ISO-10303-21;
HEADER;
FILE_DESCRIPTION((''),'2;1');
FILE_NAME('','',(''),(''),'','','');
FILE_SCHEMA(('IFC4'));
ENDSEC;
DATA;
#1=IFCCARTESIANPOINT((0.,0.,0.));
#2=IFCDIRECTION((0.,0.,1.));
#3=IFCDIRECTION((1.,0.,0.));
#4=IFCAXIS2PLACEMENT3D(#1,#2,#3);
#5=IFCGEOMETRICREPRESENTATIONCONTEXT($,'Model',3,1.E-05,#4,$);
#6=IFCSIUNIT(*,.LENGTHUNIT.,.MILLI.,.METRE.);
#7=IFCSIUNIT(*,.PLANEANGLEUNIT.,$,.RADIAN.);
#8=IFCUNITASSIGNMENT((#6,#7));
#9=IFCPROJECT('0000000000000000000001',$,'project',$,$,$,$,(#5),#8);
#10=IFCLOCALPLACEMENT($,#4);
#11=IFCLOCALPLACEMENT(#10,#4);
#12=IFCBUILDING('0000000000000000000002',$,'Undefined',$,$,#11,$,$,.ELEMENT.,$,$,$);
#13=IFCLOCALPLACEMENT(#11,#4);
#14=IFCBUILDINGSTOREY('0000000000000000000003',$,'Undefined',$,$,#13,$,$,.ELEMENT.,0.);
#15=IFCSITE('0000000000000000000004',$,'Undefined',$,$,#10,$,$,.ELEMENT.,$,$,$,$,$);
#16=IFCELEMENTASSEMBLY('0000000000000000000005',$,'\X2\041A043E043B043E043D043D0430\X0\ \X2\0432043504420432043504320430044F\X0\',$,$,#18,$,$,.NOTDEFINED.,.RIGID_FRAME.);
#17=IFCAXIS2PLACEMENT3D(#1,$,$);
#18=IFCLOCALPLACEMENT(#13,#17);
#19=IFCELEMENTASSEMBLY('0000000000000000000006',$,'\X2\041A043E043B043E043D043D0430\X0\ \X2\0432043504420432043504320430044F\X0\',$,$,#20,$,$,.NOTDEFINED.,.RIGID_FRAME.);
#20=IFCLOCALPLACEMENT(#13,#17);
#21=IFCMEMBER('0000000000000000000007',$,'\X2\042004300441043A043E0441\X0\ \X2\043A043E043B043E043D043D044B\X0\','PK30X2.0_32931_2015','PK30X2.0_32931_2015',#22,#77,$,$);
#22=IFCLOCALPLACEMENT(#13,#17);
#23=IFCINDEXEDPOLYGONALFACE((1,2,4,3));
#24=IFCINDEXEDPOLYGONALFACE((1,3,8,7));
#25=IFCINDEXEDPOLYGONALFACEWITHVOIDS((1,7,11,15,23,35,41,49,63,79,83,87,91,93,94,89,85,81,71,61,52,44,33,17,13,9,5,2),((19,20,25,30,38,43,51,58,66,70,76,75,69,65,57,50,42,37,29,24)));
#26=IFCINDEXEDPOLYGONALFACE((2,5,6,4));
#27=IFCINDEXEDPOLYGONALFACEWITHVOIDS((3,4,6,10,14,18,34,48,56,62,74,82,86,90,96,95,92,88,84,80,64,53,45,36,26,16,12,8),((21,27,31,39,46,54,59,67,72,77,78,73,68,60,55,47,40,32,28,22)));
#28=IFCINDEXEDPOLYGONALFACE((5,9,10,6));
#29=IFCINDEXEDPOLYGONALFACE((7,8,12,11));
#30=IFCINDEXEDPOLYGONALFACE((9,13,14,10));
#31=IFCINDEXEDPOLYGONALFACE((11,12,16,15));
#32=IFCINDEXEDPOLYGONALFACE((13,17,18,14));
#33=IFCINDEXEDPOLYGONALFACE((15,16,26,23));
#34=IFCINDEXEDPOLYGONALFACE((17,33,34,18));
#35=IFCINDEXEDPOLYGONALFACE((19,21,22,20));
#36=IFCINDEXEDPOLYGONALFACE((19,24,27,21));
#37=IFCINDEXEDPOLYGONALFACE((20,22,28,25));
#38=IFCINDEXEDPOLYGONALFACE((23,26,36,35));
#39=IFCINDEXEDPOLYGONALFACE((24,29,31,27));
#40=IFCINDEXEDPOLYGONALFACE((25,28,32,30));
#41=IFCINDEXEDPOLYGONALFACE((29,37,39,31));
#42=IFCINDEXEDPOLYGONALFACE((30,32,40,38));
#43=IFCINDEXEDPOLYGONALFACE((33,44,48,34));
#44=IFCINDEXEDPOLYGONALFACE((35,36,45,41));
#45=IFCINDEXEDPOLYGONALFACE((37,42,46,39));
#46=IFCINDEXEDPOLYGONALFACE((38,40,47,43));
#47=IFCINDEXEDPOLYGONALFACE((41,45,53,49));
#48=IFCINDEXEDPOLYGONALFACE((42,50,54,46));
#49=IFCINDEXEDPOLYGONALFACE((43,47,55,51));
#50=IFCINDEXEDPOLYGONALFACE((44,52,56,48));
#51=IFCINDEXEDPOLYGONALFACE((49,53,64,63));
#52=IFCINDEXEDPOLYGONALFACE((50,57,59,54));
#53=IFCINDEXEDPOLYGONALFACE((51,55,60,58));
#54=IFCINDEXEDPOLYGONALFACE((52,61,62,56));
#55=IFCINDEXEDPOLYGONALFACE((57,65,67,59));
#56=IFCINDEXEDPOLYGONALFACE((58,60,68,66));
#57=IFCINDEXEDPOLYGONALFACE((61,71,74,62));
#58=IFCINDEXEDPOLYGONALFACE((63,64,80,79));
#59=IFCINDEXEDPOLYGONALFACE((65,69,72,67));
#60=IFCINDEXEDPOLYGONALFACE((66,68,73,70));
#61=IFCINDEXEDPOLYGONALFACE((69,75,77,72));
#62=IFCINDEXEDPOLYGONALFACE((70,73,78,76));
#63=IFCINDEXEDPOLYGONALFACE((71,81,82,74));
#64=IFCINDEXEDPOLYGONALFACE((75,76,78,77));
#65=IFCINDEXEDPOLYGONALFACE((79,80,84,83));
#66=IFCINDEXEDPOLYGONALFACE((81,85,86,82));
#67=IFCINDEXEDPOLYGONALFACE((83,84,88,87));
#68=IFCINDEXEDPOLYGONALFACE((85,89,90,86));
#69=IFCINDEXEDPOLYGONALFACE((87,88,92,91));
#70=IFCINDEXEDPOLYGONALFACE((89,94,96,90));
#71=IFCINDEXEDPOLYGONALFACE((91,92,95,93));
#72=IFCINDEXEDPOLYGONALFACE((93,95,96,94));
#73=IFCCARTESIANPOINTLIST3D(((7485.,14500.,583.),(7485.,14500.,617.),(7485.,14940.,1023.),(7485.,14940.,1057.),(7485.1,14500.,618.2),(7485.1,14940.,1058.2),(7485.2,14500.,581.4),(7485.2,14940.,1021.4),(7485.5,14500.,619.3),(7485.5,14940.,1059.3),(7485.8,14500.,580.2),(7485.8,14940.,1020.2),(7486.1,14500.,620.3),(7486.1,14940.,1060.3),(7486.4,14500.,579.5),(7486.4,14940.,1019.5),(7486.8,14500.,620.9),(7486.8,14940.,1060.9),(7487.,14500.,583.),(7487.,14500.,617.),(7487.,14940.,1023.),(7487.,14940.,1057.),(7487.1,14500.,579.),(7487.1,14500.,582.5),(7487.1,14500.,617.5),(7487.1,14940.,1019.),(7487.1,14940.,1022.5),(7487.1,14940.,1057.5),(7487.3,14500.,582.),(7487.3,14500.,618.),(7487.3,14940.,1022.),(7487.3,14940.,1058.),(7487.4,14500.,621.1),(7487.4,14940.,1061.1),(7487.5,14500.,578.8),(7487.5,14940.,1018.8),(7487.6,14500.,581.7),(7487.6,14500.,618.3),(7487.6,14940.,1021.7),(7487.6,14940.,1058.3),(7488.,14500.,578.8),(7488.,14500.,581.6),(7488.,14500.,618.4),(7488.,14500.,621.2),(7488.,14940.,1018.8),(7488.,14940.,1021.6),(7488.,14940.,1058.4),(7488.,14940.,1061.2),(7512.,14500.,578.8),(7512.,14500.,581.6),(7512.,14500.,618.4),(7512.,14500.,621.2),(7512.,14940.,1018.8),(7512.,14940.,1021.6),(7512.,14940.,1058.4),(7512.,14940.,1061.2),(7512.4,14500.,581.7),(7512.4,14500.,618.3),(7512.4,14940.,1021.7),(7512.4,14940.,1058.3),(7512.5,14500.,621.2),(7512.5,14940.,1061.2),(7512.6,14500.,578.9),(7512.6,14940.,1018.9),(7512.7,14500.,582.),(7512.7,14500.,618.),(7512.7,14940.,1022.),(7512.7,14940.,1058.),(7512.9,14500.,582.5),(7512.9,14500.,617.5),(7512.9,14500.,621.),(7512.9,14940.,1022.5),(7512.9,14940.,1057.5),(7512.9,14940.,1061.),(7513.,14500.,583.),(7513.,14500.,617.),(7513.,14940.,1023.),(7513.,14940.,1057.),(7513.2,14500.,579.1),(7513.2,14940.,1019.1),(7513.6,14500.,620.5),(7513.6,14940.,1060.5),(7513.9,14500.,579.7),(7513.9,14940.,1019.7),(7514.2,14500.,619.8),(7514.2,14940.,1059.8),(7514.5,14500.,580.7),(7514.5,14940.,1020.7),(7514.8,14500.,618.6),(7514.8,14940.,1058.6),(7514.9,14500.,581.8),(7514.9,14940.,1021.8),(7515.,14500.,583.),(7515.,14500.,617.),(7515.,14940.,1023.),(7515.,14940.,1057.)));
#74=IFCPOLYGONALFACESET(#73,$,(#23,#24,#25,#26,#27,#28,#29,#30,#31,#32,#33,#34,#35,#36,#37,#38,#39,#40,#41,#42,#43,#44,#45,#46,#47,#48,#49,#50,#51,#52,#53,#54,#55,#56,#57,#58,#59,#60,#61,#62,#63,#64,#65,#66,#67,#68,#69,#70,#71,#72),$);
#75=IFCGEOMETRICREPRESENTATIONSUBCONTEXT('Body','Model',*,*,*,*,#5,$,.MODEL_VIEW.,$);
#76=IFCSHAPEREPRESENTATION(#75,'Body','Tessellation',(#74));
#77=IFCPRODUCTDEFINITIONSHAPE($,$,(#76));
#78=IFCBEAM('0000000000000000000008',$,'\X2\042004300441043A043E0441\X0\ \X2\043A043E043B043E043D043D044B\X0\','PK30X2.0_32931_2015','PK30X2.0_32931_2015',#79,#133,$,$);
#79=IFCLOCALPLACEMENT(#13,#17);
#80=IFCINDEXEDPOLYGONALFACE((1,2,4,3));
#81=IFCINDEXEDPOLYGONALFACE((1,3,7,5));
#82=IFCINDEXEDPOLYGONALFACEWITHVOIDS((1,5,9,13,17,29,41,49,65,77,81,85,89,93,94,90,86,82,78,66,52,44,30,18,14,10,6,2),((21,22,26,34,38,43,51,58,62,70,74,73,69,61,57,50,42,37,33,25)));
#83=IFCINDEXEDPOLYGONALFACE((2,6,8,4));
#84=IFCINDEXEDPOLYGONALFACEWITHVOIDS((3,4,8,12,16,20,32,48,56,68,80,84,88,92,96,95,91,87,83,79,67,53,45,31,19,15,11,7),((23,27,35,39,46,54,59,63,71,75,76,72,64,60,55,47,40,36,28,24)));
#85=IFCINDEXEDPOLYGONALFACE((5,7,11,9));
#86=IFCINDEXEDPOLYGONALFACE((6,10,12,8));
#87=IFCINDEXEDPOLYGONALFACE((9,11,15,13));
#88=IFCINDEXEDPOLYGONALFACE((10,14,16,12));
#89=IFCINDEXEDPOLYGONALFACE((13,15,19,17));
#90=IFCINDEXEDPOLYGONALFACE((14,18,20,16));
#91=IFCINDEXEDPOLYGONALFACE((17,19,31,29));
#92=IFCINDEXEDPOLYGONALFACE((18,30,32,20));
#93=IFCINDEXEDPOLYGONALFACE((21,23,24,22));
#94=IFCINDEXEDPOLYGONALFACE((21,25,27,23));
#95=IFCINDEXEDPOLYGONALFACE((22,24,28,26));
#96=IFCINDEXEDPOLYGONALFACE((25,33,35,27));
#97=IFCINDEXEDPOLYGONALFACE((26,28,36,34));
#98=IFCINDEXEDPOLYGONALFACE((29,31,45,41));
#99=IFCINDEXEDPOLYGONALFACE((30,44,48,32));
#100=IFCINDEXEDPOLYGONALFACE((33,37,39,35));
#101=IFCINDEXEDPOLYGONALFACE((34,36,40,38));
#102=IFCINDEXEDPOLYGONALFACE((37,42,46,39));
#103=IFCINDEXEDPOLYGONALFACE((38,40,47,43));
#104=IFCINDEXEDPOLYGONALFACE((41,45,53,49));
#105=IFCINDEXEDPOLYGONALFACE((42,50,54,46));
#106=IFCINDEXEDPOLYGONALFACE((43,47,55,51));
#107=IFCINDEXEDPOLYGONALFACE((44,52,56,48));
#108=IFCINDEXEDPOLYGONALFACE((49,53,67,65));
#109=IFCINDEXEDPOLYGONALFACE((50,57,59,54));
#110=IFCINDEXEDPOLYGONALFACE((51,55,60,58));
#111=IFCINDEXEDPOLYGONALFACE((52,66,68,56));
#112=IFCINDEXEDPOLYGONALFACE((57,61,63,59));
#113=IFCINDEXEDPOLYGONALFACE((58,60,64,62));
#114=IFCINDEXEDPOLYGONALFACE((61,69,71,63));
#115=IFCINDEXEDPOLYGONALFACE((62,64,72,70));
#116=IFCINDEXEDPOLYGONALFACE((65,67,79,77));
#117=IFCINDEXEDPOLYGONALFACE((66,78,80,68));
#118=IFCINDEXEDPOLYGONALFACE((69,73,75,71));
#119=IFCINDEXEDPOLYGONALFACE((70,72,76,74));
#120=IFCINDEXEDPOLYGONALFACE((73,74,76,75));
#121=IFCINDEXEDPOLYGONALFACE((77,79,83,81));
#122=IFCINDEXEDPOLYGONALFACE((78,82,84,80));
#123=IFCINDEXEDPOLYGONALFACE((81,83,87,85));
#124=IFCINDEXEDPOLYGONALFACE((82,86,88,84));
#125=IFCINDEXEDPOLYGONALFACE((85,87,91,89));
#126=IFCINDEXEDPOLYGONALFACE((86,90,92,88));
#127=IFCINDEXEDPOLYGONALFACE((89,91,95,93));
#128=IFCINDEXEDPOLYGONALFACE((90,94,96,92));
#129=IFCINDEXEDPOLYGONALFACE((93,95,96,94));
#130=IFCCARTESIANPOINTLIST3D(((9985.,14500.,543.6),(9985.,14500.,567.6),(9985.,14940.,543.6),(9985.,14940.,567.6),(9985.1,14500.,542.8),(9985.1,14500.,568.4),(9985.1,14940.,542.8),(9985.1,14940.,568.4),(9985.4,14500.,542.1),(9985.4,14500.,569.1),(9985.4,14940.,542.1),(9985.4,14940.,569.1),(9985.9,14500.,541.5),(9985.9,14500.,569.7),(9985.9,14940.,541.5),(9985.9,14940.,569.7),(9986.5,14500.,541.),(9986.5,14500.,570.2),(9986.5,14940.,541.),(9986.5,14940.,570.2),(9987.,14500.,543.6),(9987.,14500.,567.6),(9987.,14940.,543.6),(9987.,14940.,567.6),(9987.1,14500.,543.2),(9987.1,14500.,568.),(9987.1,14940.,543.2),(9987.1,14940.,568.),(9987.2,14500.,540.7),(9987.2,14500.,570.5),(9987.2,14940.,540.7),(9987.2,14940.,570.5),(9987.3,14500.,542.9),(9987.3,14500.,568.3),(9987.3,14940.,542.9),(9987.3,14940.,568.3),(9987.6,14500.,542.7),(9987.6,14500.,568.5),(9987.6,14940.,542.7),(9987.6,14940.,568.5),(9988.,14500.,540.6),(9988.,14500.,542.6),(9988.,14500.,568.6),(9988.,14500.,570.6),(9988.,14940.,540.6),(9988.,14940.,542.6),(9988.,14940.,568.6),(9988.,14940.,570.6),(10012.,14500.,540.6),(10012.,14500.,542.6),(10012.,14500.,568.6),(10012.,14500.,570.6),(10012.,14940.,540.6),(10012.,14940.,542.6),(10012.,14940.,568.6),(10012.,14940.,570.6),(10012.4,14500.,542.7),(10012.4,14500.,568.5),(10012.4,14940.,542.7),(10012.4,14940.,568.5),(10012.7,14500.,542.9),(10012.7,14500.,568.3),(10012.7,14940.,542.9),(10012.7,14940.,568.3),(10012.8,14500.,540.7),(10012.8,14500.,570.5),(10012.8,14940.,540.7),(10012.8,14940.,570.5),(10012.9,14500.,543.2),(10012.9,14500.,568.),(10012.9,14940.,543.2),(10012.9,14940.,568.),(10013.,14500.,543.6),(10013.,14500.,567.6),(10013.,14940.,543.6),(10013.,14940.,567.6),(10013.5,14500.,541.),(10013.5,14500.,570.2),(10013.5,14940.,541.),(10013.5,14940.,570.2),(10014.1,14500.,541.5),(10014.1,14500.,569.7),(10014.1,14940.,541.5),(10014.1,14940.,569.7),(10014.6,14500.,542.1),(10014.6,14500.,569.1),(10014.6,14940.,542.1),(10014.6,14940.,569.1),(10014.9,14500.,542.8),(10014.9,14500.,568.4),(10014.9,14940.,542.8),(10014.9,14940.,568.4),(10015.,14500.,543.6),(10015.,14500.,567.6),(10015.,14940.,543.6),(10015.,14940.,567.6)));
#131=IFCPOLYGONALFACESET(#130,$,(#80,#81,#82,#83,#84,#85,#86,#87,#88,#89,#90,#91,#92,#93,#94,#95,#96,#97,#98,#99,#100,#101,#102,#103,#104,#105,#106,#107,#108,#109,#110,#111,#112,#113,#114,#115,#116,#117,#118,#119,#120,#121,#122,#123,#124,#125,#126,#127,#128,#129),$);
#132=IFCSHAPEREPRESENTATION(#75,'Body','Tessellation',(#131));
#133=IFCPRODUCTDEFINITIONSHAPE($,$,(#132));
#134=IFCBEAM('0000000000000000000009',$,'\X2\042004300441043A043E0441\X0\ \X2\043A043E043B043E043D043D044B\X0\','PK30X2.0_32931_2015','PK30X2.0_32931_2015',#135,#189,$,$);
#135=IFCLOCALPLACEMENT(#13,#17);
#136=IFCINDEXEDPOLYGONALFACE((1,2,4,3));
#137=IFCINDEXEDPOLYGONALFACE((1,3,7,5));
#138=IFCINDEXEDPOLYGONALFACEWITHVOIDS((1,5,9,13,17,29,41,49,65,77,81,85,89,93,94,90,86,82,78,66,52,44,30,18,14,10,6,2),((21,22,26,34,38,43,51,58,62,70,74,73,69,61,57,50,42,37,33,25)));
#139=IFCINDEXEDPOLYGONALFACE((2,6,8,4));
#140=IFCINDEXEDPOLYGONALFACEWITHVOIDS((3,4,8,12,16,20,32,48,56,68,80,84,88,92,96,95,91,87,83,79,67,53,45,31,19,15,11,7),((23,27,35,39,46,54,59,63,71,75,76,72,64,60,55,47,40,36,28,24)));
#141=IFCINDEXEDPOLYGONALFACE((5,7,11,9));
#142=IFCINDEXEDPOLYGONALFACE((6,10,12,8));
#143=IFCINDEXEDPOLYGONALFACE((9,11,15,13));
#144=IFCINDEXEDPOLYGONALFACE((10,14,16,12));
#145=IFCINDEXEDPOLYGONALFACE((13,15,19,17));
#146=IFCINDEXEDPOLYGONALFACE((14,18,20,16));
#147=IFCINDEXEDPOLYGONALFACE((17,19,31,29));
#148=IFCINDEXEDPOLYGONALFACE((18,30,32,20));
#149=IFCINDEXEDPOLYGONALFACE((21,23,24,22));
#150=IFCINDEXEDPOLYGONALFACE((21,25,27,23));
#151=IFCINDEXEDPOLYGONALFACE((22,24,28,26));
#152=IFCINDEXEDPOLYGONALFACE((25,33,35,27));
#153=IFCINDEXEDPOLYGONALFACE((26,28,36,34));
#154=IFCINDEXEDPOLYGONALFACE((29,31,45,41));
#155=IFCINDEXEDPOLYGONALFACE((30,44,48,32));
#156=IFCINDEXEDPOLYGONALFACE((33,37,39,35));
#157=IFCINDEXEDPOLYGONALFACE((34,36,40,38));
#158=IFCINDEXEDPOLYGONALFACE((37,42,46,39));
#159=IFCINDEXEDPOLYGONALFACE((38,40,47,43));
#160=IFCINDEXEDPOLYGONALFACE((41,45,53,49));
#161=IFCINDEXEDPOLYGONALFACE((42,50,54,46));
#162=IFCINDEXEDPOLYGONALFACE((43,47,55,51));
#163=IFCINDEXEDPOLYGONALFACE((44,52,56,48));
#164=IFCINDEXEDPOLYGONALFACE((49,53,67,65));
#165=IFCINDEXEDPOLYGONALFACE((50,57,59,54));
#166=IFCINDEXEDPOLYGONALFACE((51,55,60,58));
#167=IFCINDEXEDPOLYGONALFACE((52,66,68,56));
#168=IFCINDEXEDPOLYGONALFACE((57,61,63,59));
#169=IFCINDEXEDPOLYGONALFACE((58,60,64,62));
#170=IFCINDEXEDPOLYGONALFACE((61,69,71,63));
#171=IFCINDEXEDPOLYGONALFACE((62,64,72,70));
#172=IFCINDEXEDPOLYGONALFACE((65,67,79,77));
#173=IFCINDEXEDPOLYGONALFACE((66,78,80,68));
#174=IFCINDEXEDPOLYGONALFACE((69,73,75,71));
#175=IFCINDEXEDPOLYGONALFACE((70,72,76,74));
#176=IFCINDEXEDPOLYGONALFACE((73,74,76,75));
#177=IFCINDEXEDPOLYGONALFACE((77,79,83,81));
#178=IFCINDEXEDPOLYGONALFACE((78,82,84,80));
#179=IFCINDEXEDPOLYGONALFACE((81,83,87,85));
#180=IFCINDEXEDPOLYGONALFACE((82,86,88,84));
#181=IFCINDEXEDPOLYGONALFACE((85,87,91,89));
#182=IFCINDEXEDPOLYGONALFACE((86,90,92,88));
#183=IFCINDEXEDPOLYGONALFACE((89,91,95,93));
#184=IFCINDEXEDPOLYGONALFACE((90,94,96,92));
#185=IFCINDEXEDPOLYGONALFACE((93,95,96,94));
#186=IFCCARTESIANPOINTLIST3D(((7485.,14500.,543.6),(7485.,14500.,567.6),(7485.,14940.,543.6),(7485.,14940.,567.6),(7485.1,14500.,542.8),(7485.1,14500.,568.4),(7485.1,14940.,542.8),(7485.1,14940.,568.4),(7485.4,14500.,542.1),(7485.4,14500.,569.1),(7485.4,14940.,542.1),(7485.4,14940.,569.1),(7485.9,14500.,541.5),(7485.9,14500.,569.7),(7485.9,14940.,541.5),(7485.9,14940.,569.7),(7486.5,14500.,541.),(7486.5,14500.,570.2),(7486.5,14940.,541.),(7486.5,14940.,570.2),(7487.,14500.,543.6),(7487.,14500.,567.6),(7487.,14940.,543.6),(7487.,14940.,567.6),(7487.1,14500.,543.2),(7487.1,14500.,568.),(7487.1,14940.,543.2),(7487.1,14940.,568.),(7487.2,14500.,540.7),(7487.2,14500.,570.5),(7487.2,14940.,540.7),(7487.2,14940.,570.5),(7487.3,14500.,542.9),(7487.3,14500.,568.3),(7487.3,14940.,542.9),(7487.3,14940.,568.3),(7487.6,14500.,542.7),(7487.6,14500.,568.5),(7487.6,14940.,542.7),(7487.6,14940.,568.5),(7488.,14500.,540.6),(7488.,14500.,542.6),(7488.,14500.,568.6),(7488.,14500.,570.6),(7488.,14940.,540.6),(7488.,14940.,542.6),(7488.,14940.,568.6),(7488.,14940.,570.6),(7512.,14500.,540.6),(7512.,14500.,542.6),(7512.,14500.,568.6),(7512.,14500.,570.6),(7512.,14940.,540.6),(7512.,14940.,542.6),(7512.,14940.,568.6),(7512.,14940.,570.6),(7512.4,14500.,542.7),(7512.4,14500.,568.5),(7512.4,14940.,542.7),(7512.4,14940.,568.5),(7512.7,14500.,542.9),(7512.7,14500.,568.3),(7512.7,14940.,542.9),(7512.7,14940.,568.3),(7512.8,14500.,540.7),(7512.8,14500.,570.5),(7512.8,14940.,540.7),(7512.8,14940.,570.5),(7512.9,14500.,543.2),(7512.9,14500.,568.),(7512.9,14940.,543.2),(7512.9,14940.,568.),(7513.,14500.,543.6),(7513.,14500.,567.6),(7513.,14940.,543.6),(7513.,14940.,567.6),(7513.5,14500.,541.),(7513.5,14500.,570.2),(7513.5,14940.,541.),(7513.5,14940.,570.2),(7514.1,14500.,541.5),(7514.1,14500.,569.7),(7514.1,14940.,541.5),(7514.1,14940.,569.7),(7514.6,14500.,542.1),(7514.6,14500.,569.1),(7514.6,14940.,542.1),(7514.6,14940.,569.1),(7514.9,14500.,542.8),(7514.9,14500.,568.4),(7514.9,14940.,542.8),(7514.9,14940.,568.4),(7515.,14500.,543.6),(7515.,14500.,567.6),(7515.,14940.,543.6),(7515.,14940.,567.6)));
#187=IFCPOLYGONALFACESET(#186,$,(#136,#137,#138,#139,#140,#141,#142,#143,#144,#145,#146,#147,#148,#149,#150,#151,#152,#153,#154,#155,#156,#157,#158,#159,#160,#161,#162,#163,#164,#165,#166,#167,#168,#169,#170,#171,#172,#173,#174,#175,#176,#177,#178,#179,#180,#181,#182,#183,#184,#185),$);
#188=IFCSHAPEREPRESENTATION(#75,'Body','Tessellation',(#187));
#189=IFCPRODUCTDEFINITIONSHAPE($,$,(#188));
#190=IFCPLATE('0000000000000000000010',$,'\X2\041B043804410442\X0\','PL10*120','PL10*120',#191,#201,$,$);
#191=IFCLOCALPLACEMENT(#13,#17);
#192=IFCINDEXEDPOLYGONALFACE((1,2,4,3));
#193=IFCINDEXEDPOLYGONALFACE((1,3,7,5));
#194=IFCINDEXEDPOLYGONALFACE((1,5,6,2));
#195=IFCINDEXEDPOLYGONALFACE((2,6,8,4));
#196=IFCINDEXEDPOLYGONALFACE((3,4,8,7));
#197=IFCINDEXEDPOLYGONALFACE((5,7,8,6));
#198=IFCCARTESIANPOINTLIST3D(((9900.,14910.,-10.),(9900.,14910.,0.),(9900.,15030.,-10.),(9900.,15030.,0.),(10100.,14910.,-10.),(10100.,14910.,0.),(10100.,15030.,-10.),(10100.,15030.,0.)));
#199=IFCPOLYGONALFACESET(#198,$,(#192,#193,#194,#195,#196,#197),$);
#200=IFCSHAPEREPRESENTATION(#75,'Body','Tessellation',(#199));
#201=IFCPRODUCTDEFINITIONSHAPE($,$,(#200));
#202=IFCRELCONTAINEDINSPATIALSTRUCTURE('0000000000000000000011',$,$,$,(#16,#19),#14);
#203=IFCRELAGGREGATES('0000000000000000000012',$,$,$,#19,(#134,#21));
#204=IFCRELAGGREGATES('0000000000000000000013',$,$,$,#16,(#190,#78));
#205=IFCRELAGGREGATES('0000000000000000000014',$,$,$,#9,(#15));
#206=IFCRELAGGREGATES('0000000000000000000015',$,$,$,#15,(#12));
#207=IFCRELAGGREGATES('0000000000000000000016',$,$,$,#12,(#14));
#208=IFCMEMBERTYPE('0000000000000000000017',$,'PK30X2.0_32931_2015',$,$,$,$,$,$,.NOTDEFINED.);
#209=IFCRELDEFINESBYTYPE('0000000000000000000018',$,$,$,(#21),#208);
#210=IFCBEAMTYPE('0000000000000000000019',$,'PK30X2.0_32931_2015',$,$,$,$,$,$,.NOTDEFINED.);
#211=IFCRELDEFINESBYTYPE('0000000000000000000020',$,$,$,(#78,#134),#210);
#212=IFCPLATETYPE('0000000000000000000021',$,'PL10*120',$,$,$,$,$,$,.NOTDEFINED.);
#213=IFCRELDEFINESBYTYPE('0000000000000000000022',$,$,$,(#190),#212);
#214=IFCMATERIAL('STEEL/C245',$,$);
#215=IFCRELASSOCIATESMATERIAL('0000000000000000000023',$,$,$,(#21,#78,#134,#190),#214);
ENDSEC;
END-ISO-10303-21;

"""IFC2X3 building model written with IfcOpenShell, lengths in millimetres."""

from ifc_helpers import new_model, si_unit, frame, origin_with_axes, origin_2d_with_axis, place, context, subcontext, project, spatial, polyline, hollow_rectangle, outline, extrude, clip, halfspace, material, type_object, element, aggregate, save


model = new_model("IFC2X3")

# Units and contexts
model_context = context("Model", 3, precision=1e-05, world=origin_with_axes())
body_context = subcontext(model_context, "Body", "Model", "MODEL_VIEW")
ifc_project = project(units=[si_unit("LENGTHUNIT", "METRE", prefix="MILLI"), si_unit("PLANEANGLEUNIT", "RADIAN")], contexts=[model_context])

# Site, building, storey
site_placement = place(None, origin_with_axes())
site = spatial("IfcSite", under=ifc_project, at=site_placement, Name="Undefined", CompositionType="ELEMENT")
building_placement = place(site_placement, origin_with_axes())
building = spatial("IfcBuilding", under=site, at=building_placement, Name="Undefined", CompositionType="ELEMENT")
storey_placement = place(building_placement, origin_with_axes())
storey = spatial("IfcBuildingStorey", under=building, at=storey_placement, Name="Undefined", CompositionType="ELEMENT", Elevation=0.0)

# Element assembly
assembly_1_placement = place(storey_placement, origin_with_axes())
assembly_1 = element("IfcElementAssembly", 1, at=assembly_1_placement, inside=storey, Name="Колонна ветвевая", AssemblyPlace="NOTDEFINED", PredefinedType="RIGID_FRAME")
ifc_material_1 = material(Name="STEEL/C245")

# Element assembly
assembly_2_placement = place(storey_placement, origin_with_axes())
assembly_2 = element("IfcElementAssembly", 2, at=assembly_2_placement, inside=storey, Name="Колонна ветвевая", AssemblyPlace="NOTDEFINED", PredefinedType="RIGID_FRAME")

# Member
member_type_1 = type_object("IfcMemberType", Name="PK30X2.0_32931_2015", PredefinedType="NOTDEFINED")
member_1_placement = place(assembly_2_placement, frame((7500.0, 14470.0, 570.0), z_axis=(0.0, -0.707107, 0.707107), x_axis=(0.0, 0.707107, 0.707107)))
member_1 = element("IfcMember", 3, at=member_1_placement, type_object=member_type_1, material=ifc_material_1, Name="Раскос колонны", Description="PK30X2.0_32931_2015", ObjectType="PK30X2.0_32931_2015", context=body_context, shape_type="Clipping", body=[
    clip(clip(extrude(hollow_rectangle(XDim=30.0, YDim=30.0, WallThickness=2.0, InnerFilletRadius=1.0, OuterFilletRadius=3.0, at=origin_2d_with_axis()), frame((695.0, 0.0, 0.0), z_axis=(-1.0, 0.0, 0.0), x_axis=(0.0, -1.0, 0.0)), (0.0, 0.0, 1.0), 682.9), halfspace(frame((629.0, 0.0, -35.7), z_axis=(-0.707107, 0.0, 0.707107), x_axis=(0.707107, 0.0, 0.707107)), True)), halfspace(frame((65.2, 0.0, 22.8), z_axis=(-0.707107, 0.0, 0.707107), x_axis=(0.707107, 0.0, 0.707107)), False)),
])

# Beams
beam_type_1 = type_object("IfcBeamType", Name="PK30X2.0_32931_2015", PredefinedType="NOTDEFINED")
beam_1_placement = place(assembly_1_placement, frame((10000.0, 14500.0, 555.6), z_axis=(0.0, 0.0, 1.0), x_axis=(0.0, 1.0, 0.0)))
beam_1 = element("IfcBeam", 4, at=beam_1_placement, type_object=beam_type_1, material=ifc_material_1, Name="Раскос колонны", Description="PK30X2.0_32931_2015", ObjectType="PK30X2.0_32931_2015", context=body_context, shape_type="SweptSolid", body=[
    extrude(hollow_rectangle(XDim=30.0, YDim=30.0, WallThickness=2.0, InnerFilletRadius=1.0, OuterFilletRadius=3.0, at=origin_2d_with_axis()), frame((440.0, 0.0, 0.0), z_axis=(-1.0, 0.0, 0.0), x_axis=(0.0, -1.0, 0.0)), (0.0, 0.0, 1.0), 440.0),
])
beam_2_placement = place(assembly_2_placement, frame((7500.0, 14500.0, 555.6), z_axis=(0.0, 0.0, 1.0), x_axis=(0.0, 1.0, 0.0)))
beam_2 = element("IfcBeam", 5, at=beam_2_placement, type_object=beam_type_1, material=ifc_material_1, Name="Раскос колонны", Description="PK30X2.0_32931_2015", ObjectType="PK30X2.0_32931_2015", context=body_context, shape_type="SweptSolid", body=[
    extrude(hollow_rectangle(XDim=30.0, YDim=30.0, WallThickness=2.0, InnerFilletRadius=1.0, OuterFilletRadius=3.0, at=origin_2d_with_axis()), frame((440.0, 0.0, 0.0), z_axis=(-1.0, 0.0, 0.0), x_axis=(0.0, -1.0, 0.0)), (0.0, 0.0, 1.0), 440.0),
])
aggregate(assembly_2, [beam_2, member_1])

# Plate
plate_type = type_object("IfcPlateType", Name="PL10*120", PredefinedType="NOTDEFINED")
plate_placement = place(assembly_1_placement, frame((9900.0, 14910.0, -5.0), z_axis=(0.0, 0.0, 1.0), x_axis=(1.0, 0.0, 0.0)))
plate = element("IfcPlate", 6, at=plate_placement, type_object=plate_type, material=ifc_material_1, Name="Лист", Description="PL10*120", ObjectType="PL10*120", context=body_context, shape_type="SweptSolid", body=[
    extrude(outline(polyline([(0.0, 0.0), (200.0, 0.0), (200.0, 120.0), (0.0, 120.0), (0.0, 0.0)])), frame((0.0, 0.0, -5.0), z_axis=(0.0, 0.0, 1.0), x_axis=(1.0, 0.0, 0.0)), (0.0, 0.0, 1.0), 10.0),
])
aggregate(assembly_1, [plate, beam_1])

save(model, "model.ifc")
